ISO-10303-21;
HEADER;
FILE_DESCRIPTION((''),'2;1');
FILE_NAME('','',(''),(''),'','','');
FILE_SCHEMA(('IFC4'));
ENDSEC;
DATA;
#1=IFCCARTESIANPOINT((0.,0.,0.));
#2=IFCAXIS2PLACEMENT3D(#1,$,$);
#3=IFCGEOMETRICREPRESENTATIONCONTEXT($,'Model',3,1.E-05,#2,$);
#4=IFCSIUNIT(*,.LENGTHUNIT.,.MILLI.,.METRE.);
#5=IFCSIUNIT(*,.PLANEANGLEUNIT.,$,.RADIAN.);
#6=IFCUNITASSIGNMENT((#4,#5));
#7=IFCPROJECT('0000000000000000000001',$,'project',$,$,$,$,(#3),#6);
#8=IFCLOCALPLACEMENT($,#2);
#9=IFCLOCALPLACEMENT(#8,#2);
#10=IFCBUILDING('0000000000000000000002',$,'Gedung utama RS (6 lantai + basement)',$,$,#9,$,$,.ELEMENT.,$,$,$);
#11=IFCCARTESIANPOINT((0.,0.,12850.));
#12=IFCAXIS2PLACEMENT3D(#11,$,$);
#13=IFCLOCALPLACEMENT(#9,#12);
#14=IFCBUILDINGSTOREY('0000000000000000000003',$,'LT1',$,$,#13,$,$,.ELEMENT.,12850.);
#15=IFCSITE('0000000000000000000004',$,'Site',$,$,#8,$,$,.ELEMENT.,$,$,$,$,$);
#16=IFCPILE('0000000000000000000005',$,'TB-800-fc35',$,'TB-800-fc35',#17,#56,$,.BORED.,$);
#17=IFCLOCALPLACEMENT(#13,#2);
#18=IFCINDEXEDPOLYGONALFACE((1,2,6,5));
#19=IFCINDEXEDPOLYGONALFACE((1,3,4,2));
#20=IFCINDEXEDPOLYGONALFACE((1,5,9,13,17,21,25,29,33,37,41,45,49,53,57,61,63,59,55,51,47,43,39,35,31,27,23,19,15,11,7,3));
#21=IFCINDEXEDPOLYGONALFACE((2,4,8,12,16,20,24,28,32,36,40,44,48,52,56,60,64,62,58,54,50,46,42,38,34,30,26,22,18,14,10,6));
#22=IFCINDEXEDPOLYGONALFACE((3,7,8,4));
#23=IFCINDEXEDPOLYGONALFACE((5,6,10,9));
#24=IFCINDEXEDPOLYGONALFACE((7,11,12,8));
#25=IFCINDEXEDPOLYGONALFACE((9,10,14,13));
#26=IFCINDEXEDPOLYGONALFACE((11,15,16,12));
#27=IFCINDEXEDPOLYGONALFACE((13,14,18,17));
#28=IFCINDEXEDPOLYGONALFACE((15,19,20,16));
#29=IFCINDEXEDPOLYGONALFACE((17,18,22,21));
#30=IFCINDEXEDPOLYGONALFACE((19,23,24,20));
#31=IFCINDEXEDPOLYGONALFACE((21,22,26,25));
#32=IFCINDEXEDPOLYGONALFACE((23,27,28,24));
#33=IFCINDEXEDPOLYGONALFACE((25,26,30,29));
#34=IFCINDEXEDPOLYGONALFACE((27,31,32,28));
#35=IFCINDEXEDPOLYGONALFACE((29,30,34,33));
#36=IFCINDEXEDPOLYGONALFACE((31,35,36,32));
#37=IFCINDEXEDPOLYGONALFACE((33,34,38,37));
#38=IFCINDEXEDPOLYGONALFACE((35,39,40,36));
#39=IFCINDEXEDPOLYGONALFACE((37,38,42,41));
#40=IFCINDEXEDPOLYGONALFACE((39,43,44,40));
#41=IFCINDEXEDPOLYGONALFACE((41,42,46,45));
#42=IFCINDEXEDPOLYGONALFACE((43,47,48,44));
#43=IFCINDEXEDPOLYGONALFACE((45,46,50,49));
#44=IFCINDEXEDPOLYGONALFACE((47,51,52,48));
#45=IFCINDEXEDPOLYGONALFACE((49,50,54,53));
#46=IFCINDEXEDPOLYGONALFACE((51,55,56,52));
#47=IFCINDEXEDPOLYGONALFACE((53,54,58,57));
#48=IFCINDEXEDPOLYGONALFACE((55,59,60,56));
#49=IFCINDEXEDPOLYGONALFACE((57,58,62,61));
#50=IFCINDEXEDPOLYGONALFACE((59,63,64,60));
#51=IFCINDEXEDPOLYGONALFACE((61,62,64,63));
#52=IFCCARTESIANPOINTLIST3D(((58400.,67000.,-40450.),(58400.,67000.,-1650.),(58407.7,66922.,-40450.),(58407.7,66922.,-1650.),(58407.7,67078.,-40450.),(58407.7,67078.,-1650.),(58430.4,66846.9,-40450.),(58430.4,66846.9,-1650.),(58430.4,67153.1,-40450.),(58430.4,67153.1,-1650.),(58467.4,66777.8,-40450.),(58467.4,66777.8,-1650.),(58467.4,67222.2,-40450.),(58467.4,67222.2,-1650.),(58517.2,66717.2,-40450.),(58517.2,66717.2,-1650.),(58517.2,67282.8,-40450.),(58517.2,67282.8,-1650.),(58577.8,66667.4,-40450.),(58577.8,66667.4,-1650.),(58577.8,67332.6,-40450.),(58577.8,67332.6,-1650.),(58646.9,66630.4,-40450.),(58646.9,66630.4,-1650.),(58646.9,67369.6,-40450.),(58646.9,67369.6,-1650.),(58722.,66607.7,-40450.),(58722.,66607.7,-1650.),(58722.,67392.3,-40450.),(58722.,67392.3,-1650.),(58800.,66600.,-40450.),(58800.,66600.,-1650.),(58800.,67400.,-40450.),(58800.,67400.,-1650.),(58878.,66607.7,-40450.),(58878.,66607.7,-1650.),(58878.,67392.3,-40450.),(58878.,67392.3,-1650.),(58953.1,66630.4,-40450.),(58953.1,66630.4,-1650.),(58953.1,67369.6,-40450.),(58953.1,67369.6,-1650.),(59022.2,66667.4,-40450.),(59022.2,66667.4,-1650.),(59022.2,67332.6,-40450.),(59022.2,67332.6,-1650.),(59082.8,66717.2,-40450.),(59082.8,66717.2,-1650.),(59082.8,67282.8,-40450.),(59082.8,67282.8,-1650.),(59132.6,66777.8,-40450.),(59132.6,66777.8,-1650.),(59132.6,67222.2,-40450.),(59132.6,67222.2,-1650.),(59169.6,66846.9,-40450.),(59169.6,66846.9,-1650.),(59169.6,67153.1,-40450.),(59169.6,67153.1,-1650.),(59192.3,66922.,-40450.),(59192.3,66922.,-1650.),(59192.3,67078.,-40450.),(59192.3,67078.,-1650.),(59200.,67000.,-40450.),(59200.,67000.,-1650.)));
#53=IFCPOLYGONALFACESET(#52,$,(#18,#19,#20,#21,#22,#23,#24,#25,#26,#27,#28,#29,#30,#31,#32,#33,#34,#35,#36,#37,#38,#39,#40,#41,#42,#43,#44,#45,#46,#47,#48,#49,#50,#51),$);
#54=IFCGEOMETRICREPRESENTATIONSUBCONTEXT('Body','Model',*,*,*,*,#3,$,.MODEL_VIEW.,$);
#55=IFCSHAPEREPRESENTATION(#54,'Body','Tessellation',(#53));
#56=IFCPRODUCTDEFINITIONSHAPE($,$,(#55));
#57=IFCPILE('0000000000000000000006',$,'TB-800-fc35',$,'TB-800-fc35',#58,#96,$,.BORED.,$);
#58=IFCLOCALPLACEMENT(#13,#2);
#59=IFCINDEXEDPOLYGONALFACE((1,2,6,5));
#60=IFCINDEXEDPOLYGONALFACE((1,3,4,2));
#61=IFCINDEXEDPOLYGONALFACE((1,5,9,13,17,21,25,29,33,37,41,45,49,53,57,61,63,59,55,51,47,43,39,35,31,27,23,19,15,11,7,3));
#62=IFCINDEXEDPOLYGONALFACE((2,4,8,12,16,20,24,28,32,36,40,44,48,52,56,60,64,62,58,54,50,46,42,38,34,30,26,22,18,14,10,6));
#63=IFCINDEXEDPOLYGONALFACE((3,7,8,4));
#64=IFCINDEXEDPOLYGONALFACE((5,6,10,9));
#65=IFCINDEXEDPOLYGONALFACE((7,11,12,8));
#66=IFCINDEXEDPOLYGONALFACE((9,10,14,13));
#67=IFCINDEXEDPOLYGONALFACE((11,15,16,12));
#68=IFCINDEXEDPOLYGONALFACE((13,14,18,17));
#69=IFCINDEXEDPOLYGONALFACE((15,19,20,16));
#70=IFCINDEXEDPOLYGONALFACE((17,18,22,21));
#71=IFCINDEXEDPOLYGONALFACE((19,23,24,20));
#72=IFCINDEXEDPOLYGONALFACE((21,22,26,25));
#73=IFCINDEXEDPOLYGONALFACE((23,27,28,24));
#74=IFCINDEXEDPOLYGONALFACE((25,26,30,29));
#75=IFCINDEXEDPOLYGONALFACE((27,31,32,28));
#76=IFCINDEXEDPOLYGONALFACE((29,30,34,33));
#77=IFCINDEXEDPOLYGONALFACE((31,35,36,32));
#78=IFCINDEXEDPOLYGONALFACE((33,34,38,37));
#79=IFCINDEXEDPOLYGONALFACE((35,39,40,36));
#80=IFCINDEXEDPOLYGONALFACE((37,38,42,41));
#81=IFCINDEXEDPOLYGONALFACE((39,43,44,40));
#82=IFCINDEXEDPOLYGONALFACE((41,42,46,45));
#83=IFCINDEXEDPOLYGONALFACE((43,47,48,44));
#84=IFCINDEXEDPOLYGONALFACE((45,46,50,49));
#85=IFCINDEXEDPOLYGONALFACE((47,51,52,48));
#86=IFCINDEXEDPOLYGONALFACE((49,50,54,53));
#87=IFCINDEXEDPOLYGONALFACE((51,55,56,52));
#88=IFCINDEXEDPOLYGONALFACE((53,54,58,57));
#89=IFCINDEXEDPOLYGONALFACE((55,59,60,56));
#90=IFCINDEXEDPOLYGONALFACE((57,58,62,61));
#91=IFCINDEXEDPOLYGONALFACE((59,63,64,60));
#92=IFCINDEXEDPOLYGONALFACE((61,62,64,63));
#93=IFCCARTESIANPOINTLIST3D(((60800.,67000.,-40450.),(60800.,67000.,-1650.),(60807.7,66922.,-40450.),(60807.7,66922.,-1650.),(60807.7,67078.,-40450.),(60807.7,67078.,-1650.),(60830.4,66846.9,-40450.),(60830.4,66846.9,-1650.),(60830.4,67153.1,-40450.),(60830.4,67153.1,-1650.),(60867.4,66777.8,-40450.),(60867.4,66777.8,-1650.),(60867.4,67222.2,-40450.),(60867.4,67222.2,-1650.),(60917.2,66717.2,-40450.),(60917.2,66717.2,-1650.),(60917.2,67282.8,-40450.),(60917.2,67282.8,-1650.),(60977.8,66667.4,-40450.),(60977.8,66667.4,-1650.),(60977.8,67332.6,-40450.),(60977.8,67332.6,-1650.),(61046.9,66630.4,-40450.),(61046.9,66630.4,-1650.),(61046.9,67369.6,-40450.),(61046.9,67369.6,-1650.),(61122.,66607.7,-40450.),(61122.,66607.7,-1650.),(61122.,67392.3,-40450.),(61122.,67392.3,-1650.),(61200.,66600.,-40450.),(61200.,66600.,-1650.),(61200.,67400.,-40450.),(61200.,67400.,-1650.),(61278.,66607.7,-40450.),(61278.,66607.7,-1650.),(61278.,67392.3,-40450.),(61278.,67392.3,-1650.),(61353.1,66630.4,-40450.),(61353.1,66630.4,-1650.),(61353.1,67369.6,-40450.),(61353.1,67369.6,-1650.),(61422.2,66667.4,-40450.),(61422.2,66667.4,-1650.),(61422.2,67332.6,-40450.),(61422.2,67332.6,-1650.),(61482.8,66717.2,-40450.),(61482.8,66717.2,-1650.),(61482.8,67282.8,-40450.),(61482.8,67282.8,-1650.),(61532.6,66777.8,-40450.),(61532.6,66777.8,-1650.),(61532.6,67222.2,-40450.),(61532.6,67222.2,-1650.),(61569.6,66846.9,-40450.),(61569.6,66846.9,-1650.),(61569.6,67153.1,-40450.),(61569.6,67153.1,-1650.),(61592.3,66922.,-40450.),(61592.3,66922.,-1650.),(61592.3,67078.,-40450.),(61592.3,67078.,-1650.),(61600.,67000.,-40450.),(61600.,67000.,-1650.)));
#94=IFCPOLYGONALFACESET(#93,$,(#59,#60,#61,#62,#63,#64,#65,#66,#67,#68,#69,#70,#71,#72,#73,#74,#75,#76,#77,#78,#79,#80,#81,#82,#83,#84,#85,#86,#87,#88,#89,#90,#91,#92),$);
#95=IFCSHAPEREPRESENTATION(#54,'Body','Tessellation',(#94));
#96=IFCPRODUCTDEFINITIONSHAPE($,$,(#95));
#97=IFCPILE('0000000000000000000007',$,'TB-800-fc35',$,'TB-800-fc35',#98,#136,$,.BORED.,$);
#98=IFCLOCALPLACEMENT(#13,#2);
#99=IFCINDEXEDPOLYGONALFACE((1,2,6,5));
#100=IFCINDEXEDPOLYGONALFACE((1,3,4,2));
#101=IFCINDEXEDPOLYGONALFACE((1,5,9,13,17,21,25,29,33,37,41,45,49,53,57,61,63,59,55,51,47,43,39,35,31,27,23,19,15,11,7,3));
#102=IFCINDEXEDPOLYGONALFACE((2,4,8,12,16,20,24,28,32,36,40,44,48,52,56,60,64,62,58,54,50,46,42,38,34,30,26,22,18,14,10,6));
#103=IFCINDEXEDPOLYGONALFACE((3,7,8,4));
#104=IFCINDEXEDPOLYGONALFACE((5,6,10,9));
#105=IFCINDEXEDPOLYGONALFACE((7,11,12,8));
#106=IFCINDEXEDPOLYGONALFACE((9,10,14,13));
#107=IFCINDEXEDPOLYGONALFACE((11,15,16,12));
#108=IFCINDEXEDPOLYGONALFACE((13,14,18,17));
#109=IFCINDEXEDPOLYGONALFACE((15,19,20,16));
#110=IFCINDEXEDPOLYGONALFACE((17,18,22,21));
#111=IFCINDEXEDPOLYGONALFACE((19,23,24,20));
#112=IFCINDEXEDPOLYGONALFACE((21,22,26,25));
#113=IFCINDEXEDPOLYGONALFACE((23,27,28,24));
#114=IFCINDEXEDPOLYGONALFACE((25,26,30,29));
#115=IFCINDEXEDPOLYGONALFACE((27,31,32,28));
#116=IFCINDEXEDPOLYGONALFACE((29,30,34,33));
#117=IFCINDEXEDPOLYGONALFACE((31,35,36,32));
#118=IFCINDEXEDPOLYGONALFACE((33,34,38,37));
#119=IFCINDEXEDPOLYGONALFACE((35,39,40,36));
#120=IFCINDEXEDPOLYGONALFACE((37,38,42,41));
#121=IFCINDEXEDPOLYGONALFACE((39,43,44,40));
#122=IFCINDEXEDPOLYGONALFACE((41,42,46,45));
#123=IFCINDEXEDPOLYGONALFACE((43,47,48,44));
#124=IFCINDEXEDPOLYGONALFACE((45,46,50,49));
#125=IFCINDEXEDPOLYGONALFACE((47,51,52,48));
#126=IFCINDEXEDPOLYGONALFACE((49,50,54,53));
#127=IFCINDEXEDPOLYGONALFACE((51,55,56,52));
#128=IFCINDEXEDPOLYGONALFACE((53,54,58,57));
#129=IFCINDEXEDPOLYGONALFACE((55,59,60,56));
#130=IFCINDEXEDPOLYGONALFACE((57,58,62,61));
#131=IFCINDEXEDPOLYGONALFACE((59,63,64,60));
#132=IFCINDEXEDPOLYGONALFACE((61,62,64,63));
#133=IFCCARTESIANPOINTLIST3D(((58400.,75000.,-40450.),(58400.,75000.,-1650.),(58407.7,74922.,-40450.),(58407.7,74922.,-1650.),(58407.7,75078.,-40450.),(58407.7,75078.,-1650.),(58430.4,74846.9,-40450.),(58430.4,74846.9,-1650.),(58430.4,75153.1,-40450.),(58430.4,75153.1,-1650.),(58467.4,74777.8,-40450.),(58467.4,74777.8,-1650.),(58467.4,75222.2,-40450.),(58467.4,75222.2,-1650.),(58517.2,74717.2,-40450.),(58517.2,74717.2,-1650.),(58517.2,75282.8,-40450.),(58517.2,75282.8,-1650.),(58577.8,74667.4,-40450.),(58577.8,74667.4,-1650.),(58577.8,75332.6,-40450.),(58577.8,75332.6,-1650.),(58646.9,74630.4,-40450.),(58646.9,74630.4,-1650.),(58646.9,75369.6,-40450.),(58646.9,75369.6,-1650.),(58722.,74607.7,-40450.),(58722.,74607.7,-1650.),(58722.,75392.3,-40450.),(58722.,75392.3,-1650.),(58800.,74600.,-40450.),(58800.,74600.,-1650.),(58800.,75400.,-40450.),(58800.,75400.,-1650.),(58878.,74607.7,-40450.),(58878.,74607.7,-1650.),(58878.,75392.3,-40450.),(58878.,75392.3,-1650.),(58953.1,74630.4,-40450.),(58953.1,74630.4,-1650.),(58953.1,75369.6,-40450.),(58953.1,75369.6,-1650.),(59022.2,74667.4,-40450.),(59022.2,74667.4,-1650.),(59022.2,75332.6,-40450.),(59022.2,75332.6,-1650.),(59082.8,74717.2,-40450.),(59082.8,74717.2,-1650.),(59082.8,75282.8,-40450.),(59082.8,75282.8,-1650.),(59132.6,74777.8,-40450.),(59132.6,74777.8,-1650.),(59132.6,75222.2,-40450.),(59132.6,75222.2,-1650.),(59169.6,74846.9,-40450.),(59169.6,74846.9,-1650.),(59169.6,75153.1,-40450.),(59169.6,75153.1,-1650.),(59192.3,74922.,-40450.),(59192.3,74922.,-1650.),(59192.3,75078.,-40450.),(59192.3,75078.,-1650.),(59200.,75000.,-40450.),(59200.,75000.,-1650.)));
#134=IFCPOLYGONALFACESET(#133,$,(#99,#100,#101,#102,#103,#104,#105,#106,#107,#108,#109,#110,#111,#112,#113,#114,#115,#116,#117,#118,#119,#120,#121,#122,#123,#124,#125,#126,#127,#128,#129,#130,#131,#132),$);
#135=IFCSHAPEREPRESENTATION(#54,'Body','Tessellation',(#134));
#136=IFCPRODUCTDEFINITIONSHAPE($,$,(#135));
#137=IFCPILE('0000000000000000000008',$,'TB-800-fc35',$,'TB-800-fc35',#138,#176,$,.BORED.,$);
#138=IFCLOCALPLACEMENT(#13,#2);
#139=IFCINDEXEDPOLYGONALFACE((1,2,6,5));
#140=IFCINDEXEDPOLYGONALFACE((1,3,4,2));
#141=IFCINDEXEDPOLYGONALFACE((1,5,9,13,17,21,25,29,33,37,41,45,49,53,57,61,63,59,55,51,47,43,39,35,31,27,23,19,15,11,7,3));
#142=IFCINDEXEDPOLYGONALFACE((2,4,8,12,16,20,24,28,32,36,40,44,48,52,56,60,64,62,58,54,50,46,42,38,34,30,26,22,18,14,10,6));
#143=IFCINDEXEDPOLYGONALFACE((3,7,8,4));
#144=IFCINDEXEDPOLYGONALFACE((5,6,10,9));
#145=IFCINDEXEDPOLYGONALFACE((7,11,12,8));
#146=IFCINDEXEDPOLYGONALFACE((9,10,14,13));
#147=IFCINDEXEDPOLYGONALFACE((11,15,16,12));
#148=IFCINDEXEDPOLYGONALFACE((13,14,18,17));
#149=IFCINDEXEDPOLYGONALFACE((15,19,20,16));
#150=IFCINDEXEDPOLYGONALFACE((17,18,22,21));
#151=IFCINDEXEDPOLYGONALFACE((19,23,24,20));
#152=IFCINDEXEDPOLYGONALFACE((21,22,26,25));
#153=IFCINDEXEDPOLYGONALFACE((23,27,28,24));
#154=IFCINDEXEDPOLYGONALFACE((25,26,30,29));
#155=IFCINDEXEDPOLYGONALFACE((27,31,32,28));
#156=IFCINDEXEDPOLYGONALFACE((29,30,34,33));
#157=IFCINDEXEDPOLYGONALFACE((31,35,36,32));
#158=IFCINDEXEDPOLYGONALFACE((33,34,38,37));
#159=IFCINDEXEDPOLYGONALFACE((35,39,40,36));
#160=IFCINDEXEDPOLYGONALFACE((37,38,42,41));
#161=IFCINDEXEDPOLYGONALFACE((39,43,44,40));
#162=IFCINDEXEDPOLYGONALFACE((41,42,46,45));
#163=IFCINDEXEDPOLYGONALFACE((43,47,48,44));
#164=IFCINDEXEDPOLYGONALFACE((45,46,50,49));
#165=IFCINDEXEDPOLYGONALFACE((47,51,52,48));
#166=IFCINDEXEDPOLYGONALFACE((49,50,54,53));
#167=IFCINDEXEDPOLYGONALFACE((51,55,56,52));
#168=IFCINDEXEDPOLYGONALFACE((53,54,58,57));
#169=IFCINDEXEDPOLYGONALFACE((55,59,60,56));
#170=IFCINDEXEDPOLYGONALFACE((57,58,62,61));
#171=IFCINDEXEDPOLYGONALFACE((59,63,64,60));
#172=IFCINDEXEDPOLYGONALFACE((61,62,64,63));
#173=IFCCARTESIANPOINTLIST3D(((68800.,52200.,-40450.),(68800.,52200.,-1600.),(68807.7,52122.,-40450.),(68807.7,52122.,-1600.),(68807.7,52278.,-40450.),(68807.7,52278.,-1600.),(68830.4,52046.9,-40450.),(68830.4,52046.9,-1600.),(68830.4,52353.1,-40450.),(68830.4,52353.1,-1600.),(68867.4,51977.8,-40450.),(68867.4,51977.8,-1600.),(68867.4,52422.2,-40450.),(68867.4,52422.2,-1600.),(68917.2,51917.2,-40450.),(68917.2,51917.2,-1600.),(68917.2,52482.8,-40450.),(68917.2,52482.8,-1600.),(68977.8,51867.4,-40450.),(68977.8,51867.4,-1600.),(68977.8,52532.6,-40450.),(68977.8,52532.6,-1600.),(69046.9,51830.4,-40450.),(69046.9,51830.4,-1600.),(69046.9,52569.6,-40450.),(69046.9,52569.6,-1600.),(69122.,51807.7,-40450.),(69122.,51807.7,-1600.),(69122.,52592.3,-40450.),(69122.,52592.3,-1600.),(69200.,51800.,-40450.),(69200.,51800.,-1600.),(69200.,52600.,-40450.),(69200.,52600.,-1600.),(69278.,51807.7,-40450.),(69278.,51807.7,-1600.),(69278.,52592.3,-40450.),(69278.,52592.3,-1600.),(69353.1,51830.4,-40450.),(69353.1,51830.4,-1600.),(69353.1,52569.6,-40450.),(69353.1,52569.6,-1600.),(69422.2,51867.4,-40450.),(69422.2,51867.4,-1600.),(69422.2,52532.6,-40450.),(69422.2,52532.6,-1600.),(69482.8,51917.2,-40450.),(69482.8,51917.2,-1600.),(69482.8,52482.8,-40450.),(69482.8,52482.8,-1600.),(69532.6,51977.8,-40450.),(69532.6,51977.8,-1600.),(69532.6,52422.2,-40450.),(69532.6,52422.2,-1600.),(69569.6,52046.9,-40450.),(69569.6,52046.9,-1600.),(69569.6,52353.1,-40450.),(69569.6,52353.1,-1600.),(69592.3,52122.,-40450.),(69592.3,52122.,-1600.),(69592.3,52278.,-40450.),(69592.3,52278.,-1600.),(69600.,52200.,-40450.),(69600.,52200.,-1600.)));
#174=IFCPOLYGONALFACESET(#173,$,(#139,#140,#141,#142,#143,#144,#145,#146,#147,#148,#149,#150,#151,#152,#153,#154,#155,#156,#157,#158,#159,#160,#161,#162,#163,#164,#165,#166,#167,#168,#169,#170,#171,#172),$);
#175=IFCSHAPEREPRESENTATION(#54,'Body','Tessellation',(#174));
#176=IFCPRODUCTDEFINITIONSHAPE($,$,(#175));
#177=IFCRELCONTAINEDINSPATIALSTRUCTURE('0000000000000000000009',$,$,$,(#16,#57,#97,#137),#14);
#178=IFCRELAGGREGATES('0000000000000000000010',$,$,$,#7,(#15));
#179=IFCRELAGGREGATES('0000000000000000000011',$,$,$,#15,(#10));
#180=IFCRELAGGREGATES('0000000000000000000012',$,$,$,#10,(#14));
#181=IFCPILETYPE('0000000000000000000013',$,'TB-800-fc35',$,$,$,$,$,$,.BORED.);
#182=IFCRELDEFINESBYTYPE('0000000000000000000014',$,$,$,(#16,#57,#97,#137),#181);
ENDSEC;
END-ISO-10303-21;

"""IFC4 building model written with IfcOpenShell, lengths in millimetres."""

from ifc_helpers import new_model, si_unit, frame, origin, origin_2d, place, context, subcontext, project, spatial, circle, extrude, material_profile, profile_set, profile_usage, type_object, element, save


model = new_model("IFC4")

# Units and contexts
model_context = context("Model", 3, precision=1e-05, world=origin())
body_context = subcontext(model_context, "Body", "Model", "MODEL_VIEW")
ifc_project = project(units=[si_unit("LENGTHUNIT", "METRE", prefix="MILLI"), si_unit("PLANEANGLEUNIT", "RADIAN")], contexts=[model_context])

# Site, building, storey
site_placement = place(None, origin())
site = spatial("IfcSite", under=ifc_project, at=site_placement, Name="Site", CompositionType="ELEMENT")
building_placement = place(site_placement, origin())
building = spatial("IfcBuilding", under=site, at=building_placement, Name="Gedung utama RS (6 lantai + basement)", CompositionType="ELEMENT")
storey_placement = place(building_placement, frame((0.0, 0.0, 12850.0)))
storey = spatial("IfcBuildingStorey", under=building, at=storey_placement, Name="LT1", CompositionType="ELEMENT", Elevation=12850.0)

# Piles
ifc_material_profile = material_profile(None, circle(Radius=400.0, at=origin_2d()), Name="TB-800-fc35")
ifc_profile_set = profile_set([ifc_material_profile], Name="TB-800-fc35")
ifc_profile_usage = profile_usage(ifc_profile_set, cardinal=5)
pile_type = type_object("IfcPileType", Name="TB-800-fc35", PredefinedType="BORED")
for number, where, z_axis, x_axis, name in (
    (1, (58800.0, 67000.0, -40450.0), (0.0, 0.0, 1.0), (1.0, 0.0, 0.0), "TB-800-fc35"),
    (2, (61200.0, 67000.0, -40450.0), (0.0, 0.0, 1.0), (1.0, 0.0, 0.0), "TB-800-fc35"),
    (3, (58800.0, 75000.0, -40450.0), (0.0, 0.0, 1.0), (1.0, 0.0, 0.0), "TB-800-fc35"),
):
    element("IfcPile", number, at=place(storey_placement, frame(where, z_axis=z_axis, x_axis=x_axis)), inside=storey, type_object=pile_type, material=ifc_profile_usage, Name=name, ObjectType="TB-800-fc35", PredefinedType="BORED", context=body_context, shape_type="SweptSolid", body=[
        extrude(circle(Radius=400.0, at=origin_2d()), origin(), (0.0, 0.0, 1.0), 38800.0),
    ])
for number, where, z_axis, x_axis, name in (
    (4, (69200.0, 52200.0, -40450.0), (0.0, 0.0, 1.0), (1.0, 0.0, 0.0), "TB-800-fc35"),
):
    element("IfcPile", number, at=place(storey_placement, frame(where, z_axis=z_axis, x_axis=x_axis)), inside=storey, type_object=pile_type, material=ifc_profile_usage, Name=name, ObjectType="TB-800-fc35", PredefinedType="BORED", context=body_context, shape_type="SweptSolid", body=[
        extrude(circle(Radius=400.0, at=origin_2d()), origin(), (0.0, 0.0, 1.0), 38850.0),
    ])

save(model, "model.ifc")
